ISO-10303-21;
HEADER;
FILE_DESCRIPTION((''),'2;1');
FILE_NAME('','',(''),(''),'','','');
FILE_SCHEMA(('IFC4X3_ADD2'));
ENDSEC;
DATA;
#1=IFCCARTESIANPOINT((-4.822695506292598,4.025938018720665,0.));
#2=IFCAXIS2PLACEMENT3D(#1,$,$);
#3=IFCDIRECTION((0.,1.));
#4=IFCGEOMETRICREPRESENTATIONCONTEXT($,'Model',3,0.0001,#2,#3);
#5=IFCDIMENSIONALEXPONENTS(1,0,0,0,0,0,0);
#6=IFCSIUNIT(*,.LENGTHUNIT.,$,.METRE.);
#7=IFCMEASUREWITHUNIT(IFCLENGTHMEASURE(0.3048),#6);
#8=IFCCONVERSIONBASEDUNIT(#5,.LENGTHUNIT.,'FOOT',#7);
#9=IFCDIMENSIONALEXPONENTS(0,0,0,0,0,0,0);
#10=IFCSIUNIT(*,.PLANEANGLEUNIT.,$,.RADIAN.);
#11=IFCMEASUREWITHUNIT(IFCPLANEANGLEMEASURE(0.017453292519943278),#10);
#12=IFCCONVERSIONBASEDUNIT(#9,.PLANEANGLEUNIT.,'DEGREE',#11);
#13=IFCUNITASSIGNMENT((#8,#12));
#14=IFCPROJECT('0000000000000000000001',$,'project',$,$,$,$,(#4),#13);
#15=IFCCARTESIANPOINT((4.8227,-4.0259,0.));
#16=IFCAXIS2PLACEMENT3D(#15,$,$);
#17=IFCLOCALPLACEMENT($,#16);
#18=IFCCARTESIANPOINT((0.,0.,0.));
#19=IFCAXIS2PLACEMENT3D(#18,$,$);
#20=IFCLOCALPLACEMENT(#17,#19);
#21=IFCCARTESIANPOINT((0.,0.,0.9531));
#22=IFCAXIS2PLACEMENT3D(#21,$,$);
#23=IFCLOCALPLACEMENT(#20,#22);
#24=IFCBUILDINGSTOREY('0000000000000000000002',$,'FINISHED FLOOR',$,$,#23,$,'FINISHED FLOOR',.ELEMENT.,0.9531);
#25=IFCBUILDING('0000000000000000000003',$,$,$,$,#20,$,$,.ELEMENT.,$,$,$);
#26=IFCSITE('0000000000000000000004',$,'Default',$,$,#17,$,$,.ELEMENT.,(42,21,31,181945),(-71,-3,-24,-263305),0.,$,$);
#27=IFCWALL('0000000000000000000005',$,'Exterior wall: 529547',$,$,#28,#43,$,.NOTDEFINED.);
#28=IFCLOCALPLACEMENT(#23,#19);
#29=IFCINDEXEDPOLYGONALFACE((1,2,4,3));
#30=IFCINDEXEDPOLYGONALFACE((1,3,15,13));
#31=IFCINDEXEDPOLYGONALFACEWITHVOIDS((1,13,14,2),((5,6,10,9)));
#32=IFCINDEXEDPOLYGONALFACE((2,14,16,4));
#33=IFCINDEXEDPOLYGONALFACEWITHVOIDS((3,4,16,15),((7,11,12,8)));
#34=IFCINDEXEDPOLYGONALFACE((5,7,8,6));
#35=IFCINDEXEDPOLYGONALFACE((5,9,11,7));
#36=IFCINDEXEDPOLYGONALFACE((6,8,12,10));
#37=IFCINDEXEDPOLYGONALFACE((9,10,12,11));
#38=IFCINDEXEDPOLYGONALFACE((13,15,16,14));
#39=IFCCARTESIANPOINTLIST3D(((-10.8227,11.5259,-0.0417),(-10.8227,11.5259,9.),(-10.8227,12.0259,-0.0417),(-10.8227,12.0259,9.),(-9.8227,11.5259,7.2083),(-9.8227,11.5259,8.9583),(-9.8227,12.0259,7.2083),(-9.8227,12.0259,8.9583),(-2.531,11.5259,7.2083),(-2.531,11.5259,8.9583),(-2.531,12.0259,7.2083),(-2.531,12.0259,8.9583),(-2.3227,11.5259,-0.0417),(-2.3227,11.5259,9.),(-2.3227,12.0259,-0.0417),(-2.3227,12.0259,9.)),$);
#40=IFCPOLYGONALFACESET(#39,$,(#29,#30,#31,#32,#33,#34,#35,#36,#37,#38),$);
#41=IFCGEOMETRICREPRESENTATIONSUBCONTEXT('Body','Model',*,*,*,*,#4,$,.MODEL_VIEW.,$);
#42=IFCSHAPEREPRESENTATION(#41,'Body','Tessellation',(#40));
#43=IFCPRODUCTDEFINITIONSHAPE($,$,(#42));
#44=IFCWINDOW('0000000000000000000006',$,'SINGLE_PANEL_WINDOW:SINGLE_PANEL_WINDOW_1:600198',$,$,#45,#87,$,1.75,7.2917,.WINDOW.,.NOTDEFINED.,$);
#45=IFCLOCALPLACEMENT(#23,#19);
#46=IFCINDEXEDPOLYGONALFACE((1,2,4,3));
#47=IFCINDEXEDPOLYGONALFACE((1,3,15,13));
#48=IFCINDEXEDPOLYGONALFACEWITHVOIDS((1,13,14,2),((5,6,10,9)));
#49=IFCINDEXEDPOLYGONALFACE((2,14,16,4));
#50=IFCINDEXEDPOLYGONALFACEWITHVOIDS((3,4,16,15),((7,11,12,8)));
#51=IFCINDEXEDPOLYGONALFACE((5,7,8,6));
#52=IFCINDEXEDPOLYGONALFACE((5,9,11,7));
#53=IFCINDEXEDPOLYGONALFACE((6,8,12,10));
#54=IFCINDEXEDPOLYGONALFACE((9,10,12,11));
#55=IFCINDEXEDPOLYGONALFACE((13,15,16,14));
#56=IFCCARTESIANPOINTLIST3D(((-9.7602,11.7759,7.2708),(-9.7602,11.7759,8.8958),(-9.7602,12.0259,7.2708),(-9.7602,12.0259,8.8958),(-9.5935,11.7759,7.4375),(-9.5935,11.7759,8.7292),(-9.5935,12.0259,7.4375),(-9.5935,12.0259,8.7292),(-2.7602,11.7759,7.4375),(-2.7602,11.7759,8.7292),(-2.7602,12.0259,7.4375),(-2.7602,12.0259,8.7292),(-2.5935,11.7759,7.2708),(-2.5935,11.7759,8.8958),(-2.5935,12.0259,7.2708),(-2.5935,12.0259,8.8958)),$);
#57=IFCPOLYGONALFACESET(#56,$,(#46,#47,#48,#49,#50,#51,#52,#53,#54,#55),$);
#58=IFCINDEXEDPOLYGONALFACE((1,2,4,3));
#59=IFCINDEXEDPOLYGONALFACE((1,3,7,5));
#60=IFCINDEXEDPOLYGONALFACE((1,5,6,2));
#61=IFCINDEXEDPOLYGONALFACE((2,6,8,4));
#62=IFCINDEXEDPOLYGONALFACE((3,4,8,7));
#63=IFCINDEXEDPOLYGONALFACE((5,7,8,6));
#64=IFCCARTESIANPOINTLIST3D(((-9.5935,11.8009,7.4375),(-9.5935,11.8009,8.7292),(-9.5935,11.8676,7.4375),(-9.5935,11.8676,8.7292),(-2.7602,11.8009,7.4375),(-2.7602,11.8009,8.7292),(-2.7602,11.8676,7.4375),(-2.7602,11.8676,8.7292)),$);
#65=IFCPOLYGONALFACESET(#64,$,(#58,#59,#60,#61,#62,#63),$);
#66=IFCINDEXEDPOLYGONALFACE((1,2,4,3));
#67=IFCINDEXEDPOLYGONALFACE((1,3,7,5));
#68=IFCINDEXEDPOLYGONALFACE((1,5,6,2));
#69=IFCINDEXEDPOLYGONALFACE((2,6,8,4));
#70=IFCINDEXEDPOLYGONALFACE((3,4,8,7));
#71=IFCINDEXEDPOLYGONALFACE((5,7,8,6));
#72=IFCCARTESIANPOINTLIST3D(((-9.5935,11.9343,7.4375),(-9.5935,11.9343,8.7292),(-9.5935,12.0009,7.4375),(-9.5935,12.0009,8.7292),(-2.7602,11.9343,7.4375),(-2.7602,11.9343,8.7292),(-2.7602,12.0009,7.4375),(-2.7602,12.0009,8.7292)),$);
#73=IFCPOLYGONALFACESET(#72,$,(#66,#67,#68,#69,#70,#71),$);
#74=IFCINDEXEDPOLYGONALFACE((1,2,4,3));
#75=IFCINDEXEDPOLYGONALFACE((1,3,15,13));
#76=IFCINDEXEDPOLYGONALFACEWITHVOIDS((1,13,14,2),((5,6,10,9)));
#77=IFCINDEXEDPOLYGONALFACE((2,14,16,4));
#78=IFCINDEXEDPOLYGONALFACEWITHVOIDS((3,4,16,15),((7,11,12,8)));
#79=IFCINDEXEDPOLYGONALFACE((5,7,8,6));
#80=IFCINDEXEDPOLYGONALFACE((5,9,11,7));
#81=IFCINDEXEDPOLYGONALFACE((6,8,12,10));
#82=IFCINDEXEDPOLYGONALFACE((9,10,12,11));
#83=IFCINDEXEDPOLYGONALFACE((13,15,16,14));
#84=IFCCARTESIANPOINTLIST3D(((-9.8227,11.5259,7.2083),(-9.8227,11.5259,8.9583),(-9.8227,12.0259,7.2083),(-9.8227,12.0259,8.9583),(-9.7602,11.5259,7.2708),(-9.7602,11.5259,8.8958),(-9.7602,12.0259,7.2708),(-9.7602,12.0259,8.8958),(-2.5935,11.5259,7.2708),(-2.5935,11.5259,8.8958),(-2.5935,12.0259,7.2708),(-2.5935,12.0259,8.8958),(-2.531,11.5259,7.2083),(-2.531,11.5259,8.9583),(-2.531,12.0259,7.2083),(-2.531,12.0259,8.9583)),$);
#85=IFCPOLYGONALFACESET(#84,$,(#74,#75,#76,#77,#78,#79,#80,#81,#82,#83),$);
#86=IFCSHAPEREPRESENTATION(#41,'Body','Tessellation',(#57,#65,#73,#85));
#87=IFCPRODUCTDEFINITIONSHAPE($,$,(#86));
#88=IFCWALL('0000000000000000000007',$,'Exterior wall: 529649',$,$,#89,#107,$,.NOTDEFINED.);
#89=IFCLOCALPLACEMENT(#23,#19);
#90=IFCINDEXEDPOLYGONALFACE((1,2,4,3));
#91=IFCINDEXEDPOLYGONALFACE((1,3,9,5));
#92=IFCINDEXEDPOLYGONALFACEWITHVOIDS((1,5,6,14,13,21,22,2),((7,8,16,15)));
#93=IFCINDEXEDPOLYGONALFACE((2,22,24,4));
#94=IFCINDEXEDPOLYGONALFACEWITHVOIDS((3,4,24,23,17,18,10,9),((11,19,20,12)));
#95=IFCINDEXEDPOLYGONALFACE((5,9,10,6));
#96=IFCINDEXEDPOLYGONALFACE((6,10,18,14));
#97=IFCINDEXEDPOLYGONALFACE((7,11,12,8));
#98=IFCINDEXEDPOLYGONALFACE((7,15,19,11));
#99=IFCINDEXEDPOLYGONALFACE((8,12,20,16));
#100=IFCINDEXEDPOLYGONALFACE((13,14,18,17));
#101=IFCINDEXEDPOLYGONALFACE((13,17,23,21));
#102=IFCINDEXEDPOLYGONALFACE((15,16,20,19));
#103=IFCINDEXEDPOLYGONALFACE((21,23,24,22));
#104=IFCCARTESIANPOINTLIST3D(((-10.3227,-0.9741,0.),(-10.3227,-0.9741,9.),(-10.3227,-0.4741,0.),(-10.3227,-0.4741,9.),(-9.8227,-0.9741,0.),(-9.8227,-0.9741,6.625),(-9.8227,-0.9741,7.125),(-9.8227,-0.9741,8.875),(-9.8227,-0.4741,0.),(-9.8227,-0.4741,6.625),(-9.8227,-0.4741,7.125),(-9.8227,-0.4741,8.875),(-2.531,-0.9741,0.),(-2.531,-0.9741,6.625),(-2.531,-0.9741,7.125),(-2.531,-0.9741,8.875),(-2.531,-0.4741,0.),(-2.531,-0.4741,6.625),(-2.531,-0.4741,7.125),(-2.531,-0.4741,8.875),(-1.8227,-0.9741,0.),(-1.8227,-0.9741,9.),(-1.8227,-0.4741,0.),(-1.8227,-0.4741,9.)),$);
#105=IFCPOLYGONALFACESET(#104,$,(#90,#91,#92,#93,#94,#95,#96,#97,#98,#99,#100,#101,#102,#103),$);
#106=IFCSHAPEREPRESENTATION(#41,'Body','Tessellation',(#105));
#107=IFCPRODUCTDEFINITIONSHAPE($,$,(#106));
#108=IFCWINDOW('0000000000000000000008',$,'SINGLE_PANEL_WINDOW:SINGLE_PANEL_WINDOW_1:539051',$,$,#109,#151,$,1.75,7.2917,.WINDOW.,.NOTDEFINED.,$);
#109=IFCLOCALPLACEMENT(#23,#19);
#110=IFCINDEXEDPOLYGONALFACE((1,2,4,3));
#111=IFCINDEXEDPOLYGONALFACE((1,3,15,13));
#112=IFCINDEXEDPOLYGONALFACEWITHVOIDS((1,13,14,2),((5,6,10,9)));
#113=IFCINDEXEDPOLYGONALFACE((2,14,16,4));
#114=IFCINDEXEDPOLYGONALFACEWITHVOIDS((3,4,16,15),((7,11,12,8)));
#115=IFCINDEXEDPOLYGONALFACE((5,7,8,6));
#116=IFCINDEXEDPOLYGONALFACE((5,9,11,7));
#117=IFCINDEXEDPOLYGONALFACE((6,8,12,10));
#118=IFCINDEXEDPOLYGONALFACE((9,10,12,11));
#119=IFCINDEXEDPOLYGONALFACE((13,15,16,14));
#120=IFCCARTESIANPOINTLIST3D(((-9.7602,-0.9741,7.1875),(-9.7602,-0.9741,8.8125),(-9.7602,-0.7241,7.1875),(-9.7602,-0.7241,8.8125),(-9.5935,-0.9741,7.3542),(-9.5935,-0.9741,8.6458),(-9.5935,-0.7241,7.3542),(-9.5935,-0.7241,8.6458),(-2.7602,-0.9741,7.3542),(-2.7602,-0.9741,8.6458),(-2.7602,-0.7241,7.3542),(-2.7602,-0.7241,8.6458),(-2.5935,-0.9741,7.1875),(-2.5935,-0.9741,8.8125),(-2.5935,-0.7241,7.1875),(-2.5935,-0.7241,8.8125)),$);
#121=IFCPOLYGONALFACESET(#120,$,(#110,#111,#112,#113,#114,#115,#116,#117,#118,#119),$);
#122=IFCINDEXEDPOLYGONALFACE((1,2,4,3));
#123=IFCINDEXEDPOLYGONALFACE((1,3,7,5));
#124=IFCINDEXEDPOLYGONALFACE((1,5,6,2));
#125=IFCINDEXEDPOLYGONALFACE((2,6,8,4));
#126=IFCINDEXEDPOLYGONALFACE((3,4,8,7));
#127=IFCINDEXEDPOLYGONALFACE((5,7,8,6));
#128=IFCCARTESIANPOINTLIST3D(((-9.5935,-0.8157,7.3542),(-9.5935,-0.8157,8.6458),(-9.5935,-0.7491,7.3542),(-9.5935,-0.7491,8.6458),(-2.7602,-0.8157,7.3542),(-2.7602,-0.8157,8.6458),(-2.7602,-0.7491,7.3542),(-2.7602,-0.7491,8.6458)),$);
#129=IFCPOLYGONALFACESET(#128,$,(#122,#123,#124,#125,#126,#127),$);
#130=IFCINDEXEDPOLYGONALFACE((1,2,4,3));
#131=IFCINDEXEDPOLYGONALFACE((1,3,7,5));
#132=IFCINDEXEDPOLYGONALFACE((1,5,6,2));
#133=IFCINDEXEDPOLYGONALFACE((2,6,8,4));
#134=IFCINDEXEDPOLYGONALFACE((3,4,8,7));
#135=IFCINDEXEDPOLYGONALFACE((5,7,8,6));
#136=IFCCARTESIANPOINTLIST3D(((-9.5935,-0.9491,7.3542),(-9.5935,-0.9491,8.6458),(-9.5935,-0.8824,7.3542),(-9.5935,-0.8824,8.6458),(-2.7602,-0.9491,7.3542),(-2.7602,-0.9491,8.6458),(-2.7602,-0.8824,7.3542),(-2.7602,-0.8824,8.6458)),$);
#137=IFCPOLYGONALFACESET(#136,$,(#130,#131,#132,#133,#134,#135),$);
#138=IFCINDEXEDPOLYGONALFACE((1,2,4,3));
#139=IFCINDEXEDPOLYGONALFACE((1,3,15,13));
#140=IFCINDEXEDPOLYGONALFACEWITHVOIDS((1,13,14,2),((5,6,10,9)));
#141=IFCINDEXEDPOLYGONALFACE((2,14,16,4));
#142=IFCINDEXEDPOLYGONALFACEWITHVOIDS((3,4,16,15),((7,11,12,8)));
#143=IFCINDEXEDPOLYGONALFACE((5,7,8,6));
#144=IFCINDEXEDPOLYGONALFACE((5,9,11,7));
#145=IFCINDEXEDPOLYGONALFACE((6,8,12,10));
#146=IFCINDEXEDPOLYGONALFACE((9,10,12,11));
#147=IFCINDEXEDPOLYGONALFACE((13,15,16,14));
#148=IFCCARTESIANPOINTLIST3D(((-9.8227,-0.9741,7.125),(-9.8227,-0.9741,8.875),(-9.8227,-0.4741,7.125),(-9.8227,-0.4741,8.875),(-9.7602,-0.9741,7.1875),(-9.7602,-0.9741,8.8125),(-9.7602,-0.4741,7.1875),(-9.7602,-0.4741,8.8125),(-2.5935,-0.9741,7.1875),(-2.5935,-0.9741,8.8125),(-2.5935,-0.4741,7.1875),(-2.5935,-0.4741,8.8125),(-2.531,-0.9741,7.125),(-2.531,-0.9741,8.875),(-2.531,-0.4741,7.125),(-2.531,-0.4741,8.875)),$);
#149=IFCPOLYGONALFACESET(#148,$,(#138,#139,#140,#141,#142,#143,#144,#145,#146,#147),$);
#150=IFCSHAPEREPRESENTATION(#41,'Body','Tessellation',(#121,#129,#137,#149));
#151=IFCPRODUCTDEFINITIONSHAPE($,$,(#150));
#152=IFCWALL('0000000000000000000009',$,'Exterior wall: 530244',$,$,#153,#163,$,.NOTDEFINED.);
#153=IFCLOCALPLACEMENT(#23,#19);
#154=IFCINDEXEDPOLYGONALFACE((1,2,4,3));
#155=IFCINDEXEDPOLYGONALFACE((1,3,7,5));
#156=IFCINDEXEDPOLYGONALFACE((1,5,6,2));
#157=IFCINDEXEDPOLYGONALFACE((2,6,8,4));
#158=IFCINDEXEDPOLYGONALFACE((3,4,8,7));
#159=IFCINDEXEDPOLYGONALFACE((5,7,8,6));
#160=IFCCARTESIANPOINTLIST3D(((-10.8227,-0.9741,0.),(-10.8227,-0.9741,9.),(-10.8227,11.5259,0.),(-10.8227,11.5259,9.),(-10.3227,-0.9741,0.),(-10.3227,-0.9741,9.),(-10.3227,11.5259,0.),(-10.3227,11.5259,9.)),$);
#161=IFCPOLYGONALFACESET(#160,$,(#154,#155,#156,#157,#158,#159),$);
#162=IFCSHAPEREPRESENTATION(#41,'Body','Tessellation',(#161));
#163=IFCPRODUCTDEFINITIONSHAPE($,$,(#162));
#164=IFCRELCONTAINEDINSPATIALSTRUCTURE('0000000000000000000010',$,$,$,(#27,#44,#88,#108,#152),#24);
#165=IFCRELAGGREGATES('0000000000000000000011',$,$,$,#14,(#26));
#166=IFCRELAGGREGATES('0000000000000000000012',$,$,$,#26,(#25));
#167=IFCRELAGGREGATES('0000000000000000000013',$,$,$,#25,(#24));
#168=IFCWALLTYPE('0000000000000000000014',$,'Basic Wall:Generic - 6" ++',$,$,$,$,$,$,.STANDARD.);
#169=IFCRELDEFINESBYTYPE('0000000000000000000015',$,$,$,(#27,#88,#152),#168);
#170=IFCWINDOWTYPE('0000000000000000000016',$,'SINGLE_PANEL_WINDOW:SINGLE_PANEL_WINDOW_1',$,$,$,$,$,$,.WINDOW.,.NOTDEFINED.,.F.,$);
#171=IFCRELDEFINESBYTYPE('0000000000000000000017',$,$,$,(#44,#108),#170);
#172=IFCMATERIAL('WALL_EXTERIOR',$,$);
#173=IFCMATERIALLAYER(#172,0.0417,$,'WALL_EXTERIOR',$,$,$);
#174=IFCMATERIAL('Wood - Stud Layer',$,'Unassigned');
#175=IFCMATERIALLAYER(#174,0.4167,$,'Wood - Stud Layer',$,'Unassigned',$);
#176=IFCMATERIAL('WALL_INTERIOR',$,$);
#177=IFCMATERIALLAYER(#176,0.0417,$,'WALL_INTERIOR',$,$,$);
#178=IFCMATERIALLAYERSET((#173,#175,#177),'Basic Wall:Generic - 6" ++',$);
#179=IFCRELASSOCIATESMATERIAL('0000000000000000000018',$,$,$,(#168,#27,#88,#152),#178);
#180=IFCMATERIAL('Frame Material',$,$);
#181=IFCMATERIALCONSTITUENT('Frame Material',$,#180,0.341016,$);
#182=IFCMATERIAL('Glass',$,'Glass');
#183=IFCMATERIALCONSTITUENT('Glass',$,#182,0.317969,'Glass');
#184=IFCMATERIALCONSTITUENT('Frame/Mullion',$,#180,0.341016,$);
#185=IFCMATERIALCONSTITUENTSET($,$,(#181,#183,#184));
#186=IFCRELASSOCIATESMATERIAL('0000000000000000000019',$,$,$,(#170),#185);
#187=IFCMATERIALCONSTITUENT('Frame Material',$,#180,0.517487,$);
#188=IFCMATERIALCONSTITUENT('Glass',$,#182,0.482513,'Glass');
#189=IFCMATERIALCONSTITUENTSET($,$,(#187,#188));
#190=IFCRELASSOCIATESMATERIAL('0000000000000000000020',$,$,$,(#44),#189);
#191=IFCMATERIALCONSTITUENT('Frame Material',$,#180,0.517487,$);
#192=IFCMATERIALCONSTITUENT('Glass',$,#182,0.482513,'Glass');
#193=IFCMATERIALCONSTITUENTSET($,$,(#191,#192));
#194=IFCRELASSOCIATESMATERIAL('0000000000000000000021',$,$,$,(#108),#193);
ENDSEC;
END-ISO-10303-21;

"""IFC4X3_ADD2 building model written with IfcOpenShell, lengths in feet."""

from ifc_helpers import new_model, entity, si_unit, converted_unit, direction, frame, frame_2d, origin, origin_2d_with_axis, place, context, subcontext, project, spatial, polyline, rectangle, outline, extrude, source, transform, mapped, material, layer, layer_set, constituent, constituent_set, type_object, type_shapes, element, fill, save


model = new_model("IFC4X3_ADD2")

# Units and contexts
model_context = context("Model", 3, precision=0.0001, world=frame((-4.822695506292598, 4.025938018720665, 0.0)), true_north=direction((0.0, 1.0)))
body_context = subcontext(model_context, "Body", "Model", "MODEL_VIEW")
ifc_project = project(units=[converted_unit("LENGTHUNIT", "FOOT", entity("IfcLengthMeasure", 0.3048), si_unit("LENGTHUNIT", "METRE"), dimensions=[1, 0, 0, 0, 0, 0, 0]), converted_unit("PLANEANGLEUNIT", "DEGREE", entity("IfcPlaneAngleMeasure", 0.017453292519943278), si_unit("PLANEANGLEUNIT", "RADIAN"), dimensions=[0, 0, 0, 0, 0, 0, 0])], contexts=[model_context])

# Site, building, storey
site_placement = place(None, frame((4.8227, -4.0259, 0.0)))
site = spatial("IfcSite", under=ifc_project, at=site_placement, Name="Default", CompositionType="ELEMENT", RefLatitude=(42, 21, 31, 181945), RefLongitude=(-71, -3, -24, -263305), RefElevation=0.0)
building_placement = place(site_placement, origin())
building = spatial("IfcBuilding", under=site, at=building_placement, CompositionType="ELEMENT")
storey_placement = place(building_placement, frame((0.0, 0.0, 0.9531)))
storey = spatial("IfcBuildingStorey", under=building, at=storey_placement, Name="FINISHED FLOOR", LongName="FINISHED FLOOR", CompositionType="ELEMENT", Elevation=0.9531)

# Wall, opening, window
ifc_material_1 = material(Name="WALL_EXTERIOR")
ifc_layer_1 = layer(ifc_material_1, 0.0417, Name="WALL_EXTERIOR")
ifc_material_2 = material(Name="Wood - Stud Layer", Category="Unassigned")
ifc_layer_2 = layer(ifc_material_2, 0.4167, Name="Wood - Stud Layer", Category="Unassigned")
ifc_material_3 = material(Name="WALL_INTERIOR")
ifc_layer_3 = layer(ifc_material_3, 0.0417, Name="WALL_INTERIOR")
ifc_layer_set_1 = layer_set([ifc_layer_1, ifc_layer_2, ifc_layer_3], Name="Basic Wall:Generic - 6\" ++")
wall_type_1 = type_object("IfcWallType", Name="Basic Wall:Generic - 6\" ++", PredefinedType="STANDARD", material=ifc_layer_set_1)
wall_1_placement = place(storey_placement, frame((-10.8227, 11.7759, -0.0417)))
wall_1 = element("IfcWall", 1, at=wall_1_placement, inside=storey, type_object=wall_type_1, material=ifc_layer_set_1, Name="Exterior wall: 529547", PredefinedType="NOTDEFINED", context=body_context, shape_type="SweptSolid", body=[
    extrude(rectangle(XDim=8.5, YDim=0.5, at=frame_2d((4.25, 0.0))), origin(), (0.0, 0.0, 1.0), 9.0417),
])
opening_1_placement = place(wall_1_placement, frame((1.0, -0.25, 7.25)))
opening_1 = element("IfcOpeningElement", 2, at=opening_1_placement, cuts=wall_1, PredefinedType="OPENING", context=body_context, shape_type="SweptSolid", body=[
    extrude(rectangle(XDim=1.75, YDim=7.2917, at=frame_2d((0.875, 3.6458), x_axis=(-1.0, 0.0))), frame((0.0, 0.0, 0.0), z_axis=(0.0, 1.0, 0.0), x_axis=(0.0, 0.0, 1.0)), (0.0, 0.0, 1.0), 0.5),
])
ifc_material_4 = material(Name="Frame Material")
ifc_constituent_1 = constituent(ifc_material_4, Name="Frame Material", fraction=0.517487)
ifc_material_5 = material(Name="Glass", Category="Glass")
ifc_constituent_2 = constituent(ifc_material_5, Name="Glass", Category="Glass", fraction=0.482513)
ifc_constituent_set_1 = constituent_set(constituents=[ifc_constituent_1, ifc_constituent_2])
ifc_constituent_3 = constituent(ifc_material_4, Name="Frame Material", fraction=0.341016)
ifc_constituent_4 = constituent(ifc_material_5, Name="Glass", Category="Glass", fraction=0.317969)
ifc_constituent_5 = constituent(ifc_material_4, Name="Frame/Mullion", fraction=0.341016)
ifc_constituent_set_2 = constituent_set(constituents=[ifc_constituent_3, ifc_constituent_4, ifc_constituent_5])
window_type_1 = type_object("IfcWindowType", Name="SINGLE_PANEL_WINDOW:SINGLE_PANEL_WINDOW_1", ParameterTakesPrecedence=False, PartitioningType="NOTDEFINED", PredefinedType="WINDOW", material=ifc_constituent_set_2)
shared_shape_1 = source(origin(), body_context, "Body", "SweptSolid", [
    extrude(outline(polyline([(-3.5833, -0.8125), (3.5833, -0.8125), (3.5833, 0.8125), (-3.5833, 0.8125), (-3.5833, -0.8125)]), holes=[polyline([(3.4167, 0.6458), (3.4167, -0.6458), (-3.4167, -0.6458), (-3.4167, 0.6458), (3.4167, 0.6458)])]), frame((3.6458, 0.5, 0.875), z_axis=(0.0, -1.0, 0.0), x_axis=(-1.0, 0.0, 0.0)), (0.0, 0.0, 1.0), 0.25),
    extrude(rectangle(XDim=6.8333, YDim=0.0667, at=frame_2d((0.0, 0.0), x_axis=(1.0, 0.0))), frame((3.6458, 0.3083, 0.2292), z_axis=(0.0, 0.0, 1.0), x_axis=(-1.0, 0.0, 0.0)), (0.0, 0.0, 1.0), 1.2917),
    extrude(rectangle(XDim=6.8333, YDim=0.0667, at=origin_2d_with_axis()), frame((3.6458, 0.4417, 0.2292), z_axis=(0.0, 0.0, 1.0), x_axis=(-1.0, 0.0, 0.0)), (0.0, 0.0, 1.0), 1.2917),
    extrude(outline(polyline([(-0.875, -3.6458), (0.875, -3.6458), (0.875, 3.6458), (-0.875, 3.6458), (-0.875, -3.6458)]), holes=[polyline([(-0.8125, -3.5833), (-0.8125, 3.5833), (0.8125, 3.5833), (0.8125, -3.5833), (-0.8125, -3.5833)])]), frame((3.6458, 0.5, 0.875), z_axis=(0.0, -1.0, 0.0), x_axis=(0.0, 0.0, -1.0)), (0.0, 0.0, 1.0), 0.5),
])
type_shapes(window_type_1, [shared_shape_1])
window_1_placement = place(opening_1_placement, origin())
window_1 = element("IfcWindow", 3, at=window_1_placement, inside=storey, type_object=window_type_1, material=ifc_constituent_set_1, Name="SINGLE_PANEL_WINDOW:SINGLE_PANEL_WINDOW_1:600198", OverallHeight=1.75, OverallWidth=7.2917, PartitioningType="NOTDEFINED", PredefinedType="WINDOW", context=body_context, shape_type="MappedRepresentation", body=[
    mapped(shared_shape_1, transform((0.0, 0.0, 0.0), scale=1.0)),
])
fill(opening_1, window_1)

# Wall, openings, window
wall_2_placement = place(storey_placement, frame((-1.8227, -0.7241, 0.0), z_axis=(0.0, 0.0, 1.0), x_axis=(-1.0, 0.0, 0.0)))
wall_2 = element("IfcWall", 4, at=wall_2_placement, inside=storey, type_object=wall_type_1, material=ifc_layer_set_1, Name="Exterior wall: 529649", PredefinedType="NOTDEFINED", context=body_context, shape_type="SweptSolid", body=[
    extrude(rectangle(XDim=8.5, YDim=0.5, at=frame_2d((4.25, 0.0))), origin(), (0.0, 0.0, 1.0), 9.0),
])
opening_2_placement = place(wall_2_placement, frame((-1.8227, -0.7241, 0.0), z_axis=(0.0, 0.0, 1.0), x_axis=(-1.0, 0.0, 0.0)))
element("IfcOpeningElement", 5, at=opening_2_placement, cuts=wall_2, PredefinedType="OPENING", context=body_context, shape_type="SweptSolid", body=[
    extrude(rectangle(XDim=6.625, YDim=7.2917, at=origin_2d_with_axis()), frame((-6.1769, -0.4741, 3.3125), z_axis=(0.0, -1.0, 0.0), x_axis=(0.0, 0.0, -1.0)), (0.0, 0.0, 1.0), 0.5),
])
opening_3_placement = place(wall_2_placement, frame((0.7083, -0.25, 7.125)))
opening_3 = element("IfcOpeningElement", 6, at=opening_3_placement, cuts=wall_2, PredefinedType="OPENING", context=body_context, shape_type="SweptSolid", body=[
    extrude(rectangle(XDim=1.75, YDim=7.2917, at=frame_2d((0.875, 3.6458), x_axis=(-1.0, 0.0))), frame((0.0, 0.0, 0.0), z_axis=(0.0, 1.0, 0.0), x_axis=(0.0, 0.0, 1.0)), (0.0, 0.0, 1.0), 0.5),
])
ifc_constituent_6 = constituent(ifc_material_4, Name="Frame Material", fraction=0.517487)
ifc_constituent_7 = constituent(ifc_material_5, Name="Glass", Category="Glass", fraction=0.482513)
ifc_constituent_set_3 = constituent_set(constituents=[ifc_constituent_6, ifc_constituent_7])
window_2_placement = place(opening_3_placement, origin())
window_2 = element("IfcWindow", 7, at=window_2_placement, inside=storey, type_object=window_type_1, material=ifc_constituent_set_3, Name="SINGLE_PANEL_WINDOW:SINGLE_PANEL_WINDOW_1:539051", OverallHeight=1.75, OverallWidth=7.2917, PartitioningType="NOTDEFINED", PredefinedType="WINDOW", context=body_context, shape_type="MappedRepresentation", body=[
    mapped(shared_shape_1, transform((0.0, 0.0, 0.0), scale=1.0)),
])
fill(opening_3, window_2)

# Wall
wall_3_placement = place(storey_placement, frame((-10.5727, -0.9741, 0.0), z_axis=(0.0, 0.0, 1.0), x_axis=(0.0, 1.0, 0.0)))
element("IfcWall", 8, at=wall_3_placement, inside=storey, type_object=wall_type_1, material=ifc_layer_set_1, Name="Exterior wall: 530244", PredefinedType="NOTDEFINED", context=body_context, shape_type="SweptSolid", body=[
    extrude(rectangle(XDim=12.5, YDim=0.5, at=frame_2d((6.25, 0.0))), origin(), (0.0, 0.0, 1.0), 9.0),
])

save(model, "model.ifc")
